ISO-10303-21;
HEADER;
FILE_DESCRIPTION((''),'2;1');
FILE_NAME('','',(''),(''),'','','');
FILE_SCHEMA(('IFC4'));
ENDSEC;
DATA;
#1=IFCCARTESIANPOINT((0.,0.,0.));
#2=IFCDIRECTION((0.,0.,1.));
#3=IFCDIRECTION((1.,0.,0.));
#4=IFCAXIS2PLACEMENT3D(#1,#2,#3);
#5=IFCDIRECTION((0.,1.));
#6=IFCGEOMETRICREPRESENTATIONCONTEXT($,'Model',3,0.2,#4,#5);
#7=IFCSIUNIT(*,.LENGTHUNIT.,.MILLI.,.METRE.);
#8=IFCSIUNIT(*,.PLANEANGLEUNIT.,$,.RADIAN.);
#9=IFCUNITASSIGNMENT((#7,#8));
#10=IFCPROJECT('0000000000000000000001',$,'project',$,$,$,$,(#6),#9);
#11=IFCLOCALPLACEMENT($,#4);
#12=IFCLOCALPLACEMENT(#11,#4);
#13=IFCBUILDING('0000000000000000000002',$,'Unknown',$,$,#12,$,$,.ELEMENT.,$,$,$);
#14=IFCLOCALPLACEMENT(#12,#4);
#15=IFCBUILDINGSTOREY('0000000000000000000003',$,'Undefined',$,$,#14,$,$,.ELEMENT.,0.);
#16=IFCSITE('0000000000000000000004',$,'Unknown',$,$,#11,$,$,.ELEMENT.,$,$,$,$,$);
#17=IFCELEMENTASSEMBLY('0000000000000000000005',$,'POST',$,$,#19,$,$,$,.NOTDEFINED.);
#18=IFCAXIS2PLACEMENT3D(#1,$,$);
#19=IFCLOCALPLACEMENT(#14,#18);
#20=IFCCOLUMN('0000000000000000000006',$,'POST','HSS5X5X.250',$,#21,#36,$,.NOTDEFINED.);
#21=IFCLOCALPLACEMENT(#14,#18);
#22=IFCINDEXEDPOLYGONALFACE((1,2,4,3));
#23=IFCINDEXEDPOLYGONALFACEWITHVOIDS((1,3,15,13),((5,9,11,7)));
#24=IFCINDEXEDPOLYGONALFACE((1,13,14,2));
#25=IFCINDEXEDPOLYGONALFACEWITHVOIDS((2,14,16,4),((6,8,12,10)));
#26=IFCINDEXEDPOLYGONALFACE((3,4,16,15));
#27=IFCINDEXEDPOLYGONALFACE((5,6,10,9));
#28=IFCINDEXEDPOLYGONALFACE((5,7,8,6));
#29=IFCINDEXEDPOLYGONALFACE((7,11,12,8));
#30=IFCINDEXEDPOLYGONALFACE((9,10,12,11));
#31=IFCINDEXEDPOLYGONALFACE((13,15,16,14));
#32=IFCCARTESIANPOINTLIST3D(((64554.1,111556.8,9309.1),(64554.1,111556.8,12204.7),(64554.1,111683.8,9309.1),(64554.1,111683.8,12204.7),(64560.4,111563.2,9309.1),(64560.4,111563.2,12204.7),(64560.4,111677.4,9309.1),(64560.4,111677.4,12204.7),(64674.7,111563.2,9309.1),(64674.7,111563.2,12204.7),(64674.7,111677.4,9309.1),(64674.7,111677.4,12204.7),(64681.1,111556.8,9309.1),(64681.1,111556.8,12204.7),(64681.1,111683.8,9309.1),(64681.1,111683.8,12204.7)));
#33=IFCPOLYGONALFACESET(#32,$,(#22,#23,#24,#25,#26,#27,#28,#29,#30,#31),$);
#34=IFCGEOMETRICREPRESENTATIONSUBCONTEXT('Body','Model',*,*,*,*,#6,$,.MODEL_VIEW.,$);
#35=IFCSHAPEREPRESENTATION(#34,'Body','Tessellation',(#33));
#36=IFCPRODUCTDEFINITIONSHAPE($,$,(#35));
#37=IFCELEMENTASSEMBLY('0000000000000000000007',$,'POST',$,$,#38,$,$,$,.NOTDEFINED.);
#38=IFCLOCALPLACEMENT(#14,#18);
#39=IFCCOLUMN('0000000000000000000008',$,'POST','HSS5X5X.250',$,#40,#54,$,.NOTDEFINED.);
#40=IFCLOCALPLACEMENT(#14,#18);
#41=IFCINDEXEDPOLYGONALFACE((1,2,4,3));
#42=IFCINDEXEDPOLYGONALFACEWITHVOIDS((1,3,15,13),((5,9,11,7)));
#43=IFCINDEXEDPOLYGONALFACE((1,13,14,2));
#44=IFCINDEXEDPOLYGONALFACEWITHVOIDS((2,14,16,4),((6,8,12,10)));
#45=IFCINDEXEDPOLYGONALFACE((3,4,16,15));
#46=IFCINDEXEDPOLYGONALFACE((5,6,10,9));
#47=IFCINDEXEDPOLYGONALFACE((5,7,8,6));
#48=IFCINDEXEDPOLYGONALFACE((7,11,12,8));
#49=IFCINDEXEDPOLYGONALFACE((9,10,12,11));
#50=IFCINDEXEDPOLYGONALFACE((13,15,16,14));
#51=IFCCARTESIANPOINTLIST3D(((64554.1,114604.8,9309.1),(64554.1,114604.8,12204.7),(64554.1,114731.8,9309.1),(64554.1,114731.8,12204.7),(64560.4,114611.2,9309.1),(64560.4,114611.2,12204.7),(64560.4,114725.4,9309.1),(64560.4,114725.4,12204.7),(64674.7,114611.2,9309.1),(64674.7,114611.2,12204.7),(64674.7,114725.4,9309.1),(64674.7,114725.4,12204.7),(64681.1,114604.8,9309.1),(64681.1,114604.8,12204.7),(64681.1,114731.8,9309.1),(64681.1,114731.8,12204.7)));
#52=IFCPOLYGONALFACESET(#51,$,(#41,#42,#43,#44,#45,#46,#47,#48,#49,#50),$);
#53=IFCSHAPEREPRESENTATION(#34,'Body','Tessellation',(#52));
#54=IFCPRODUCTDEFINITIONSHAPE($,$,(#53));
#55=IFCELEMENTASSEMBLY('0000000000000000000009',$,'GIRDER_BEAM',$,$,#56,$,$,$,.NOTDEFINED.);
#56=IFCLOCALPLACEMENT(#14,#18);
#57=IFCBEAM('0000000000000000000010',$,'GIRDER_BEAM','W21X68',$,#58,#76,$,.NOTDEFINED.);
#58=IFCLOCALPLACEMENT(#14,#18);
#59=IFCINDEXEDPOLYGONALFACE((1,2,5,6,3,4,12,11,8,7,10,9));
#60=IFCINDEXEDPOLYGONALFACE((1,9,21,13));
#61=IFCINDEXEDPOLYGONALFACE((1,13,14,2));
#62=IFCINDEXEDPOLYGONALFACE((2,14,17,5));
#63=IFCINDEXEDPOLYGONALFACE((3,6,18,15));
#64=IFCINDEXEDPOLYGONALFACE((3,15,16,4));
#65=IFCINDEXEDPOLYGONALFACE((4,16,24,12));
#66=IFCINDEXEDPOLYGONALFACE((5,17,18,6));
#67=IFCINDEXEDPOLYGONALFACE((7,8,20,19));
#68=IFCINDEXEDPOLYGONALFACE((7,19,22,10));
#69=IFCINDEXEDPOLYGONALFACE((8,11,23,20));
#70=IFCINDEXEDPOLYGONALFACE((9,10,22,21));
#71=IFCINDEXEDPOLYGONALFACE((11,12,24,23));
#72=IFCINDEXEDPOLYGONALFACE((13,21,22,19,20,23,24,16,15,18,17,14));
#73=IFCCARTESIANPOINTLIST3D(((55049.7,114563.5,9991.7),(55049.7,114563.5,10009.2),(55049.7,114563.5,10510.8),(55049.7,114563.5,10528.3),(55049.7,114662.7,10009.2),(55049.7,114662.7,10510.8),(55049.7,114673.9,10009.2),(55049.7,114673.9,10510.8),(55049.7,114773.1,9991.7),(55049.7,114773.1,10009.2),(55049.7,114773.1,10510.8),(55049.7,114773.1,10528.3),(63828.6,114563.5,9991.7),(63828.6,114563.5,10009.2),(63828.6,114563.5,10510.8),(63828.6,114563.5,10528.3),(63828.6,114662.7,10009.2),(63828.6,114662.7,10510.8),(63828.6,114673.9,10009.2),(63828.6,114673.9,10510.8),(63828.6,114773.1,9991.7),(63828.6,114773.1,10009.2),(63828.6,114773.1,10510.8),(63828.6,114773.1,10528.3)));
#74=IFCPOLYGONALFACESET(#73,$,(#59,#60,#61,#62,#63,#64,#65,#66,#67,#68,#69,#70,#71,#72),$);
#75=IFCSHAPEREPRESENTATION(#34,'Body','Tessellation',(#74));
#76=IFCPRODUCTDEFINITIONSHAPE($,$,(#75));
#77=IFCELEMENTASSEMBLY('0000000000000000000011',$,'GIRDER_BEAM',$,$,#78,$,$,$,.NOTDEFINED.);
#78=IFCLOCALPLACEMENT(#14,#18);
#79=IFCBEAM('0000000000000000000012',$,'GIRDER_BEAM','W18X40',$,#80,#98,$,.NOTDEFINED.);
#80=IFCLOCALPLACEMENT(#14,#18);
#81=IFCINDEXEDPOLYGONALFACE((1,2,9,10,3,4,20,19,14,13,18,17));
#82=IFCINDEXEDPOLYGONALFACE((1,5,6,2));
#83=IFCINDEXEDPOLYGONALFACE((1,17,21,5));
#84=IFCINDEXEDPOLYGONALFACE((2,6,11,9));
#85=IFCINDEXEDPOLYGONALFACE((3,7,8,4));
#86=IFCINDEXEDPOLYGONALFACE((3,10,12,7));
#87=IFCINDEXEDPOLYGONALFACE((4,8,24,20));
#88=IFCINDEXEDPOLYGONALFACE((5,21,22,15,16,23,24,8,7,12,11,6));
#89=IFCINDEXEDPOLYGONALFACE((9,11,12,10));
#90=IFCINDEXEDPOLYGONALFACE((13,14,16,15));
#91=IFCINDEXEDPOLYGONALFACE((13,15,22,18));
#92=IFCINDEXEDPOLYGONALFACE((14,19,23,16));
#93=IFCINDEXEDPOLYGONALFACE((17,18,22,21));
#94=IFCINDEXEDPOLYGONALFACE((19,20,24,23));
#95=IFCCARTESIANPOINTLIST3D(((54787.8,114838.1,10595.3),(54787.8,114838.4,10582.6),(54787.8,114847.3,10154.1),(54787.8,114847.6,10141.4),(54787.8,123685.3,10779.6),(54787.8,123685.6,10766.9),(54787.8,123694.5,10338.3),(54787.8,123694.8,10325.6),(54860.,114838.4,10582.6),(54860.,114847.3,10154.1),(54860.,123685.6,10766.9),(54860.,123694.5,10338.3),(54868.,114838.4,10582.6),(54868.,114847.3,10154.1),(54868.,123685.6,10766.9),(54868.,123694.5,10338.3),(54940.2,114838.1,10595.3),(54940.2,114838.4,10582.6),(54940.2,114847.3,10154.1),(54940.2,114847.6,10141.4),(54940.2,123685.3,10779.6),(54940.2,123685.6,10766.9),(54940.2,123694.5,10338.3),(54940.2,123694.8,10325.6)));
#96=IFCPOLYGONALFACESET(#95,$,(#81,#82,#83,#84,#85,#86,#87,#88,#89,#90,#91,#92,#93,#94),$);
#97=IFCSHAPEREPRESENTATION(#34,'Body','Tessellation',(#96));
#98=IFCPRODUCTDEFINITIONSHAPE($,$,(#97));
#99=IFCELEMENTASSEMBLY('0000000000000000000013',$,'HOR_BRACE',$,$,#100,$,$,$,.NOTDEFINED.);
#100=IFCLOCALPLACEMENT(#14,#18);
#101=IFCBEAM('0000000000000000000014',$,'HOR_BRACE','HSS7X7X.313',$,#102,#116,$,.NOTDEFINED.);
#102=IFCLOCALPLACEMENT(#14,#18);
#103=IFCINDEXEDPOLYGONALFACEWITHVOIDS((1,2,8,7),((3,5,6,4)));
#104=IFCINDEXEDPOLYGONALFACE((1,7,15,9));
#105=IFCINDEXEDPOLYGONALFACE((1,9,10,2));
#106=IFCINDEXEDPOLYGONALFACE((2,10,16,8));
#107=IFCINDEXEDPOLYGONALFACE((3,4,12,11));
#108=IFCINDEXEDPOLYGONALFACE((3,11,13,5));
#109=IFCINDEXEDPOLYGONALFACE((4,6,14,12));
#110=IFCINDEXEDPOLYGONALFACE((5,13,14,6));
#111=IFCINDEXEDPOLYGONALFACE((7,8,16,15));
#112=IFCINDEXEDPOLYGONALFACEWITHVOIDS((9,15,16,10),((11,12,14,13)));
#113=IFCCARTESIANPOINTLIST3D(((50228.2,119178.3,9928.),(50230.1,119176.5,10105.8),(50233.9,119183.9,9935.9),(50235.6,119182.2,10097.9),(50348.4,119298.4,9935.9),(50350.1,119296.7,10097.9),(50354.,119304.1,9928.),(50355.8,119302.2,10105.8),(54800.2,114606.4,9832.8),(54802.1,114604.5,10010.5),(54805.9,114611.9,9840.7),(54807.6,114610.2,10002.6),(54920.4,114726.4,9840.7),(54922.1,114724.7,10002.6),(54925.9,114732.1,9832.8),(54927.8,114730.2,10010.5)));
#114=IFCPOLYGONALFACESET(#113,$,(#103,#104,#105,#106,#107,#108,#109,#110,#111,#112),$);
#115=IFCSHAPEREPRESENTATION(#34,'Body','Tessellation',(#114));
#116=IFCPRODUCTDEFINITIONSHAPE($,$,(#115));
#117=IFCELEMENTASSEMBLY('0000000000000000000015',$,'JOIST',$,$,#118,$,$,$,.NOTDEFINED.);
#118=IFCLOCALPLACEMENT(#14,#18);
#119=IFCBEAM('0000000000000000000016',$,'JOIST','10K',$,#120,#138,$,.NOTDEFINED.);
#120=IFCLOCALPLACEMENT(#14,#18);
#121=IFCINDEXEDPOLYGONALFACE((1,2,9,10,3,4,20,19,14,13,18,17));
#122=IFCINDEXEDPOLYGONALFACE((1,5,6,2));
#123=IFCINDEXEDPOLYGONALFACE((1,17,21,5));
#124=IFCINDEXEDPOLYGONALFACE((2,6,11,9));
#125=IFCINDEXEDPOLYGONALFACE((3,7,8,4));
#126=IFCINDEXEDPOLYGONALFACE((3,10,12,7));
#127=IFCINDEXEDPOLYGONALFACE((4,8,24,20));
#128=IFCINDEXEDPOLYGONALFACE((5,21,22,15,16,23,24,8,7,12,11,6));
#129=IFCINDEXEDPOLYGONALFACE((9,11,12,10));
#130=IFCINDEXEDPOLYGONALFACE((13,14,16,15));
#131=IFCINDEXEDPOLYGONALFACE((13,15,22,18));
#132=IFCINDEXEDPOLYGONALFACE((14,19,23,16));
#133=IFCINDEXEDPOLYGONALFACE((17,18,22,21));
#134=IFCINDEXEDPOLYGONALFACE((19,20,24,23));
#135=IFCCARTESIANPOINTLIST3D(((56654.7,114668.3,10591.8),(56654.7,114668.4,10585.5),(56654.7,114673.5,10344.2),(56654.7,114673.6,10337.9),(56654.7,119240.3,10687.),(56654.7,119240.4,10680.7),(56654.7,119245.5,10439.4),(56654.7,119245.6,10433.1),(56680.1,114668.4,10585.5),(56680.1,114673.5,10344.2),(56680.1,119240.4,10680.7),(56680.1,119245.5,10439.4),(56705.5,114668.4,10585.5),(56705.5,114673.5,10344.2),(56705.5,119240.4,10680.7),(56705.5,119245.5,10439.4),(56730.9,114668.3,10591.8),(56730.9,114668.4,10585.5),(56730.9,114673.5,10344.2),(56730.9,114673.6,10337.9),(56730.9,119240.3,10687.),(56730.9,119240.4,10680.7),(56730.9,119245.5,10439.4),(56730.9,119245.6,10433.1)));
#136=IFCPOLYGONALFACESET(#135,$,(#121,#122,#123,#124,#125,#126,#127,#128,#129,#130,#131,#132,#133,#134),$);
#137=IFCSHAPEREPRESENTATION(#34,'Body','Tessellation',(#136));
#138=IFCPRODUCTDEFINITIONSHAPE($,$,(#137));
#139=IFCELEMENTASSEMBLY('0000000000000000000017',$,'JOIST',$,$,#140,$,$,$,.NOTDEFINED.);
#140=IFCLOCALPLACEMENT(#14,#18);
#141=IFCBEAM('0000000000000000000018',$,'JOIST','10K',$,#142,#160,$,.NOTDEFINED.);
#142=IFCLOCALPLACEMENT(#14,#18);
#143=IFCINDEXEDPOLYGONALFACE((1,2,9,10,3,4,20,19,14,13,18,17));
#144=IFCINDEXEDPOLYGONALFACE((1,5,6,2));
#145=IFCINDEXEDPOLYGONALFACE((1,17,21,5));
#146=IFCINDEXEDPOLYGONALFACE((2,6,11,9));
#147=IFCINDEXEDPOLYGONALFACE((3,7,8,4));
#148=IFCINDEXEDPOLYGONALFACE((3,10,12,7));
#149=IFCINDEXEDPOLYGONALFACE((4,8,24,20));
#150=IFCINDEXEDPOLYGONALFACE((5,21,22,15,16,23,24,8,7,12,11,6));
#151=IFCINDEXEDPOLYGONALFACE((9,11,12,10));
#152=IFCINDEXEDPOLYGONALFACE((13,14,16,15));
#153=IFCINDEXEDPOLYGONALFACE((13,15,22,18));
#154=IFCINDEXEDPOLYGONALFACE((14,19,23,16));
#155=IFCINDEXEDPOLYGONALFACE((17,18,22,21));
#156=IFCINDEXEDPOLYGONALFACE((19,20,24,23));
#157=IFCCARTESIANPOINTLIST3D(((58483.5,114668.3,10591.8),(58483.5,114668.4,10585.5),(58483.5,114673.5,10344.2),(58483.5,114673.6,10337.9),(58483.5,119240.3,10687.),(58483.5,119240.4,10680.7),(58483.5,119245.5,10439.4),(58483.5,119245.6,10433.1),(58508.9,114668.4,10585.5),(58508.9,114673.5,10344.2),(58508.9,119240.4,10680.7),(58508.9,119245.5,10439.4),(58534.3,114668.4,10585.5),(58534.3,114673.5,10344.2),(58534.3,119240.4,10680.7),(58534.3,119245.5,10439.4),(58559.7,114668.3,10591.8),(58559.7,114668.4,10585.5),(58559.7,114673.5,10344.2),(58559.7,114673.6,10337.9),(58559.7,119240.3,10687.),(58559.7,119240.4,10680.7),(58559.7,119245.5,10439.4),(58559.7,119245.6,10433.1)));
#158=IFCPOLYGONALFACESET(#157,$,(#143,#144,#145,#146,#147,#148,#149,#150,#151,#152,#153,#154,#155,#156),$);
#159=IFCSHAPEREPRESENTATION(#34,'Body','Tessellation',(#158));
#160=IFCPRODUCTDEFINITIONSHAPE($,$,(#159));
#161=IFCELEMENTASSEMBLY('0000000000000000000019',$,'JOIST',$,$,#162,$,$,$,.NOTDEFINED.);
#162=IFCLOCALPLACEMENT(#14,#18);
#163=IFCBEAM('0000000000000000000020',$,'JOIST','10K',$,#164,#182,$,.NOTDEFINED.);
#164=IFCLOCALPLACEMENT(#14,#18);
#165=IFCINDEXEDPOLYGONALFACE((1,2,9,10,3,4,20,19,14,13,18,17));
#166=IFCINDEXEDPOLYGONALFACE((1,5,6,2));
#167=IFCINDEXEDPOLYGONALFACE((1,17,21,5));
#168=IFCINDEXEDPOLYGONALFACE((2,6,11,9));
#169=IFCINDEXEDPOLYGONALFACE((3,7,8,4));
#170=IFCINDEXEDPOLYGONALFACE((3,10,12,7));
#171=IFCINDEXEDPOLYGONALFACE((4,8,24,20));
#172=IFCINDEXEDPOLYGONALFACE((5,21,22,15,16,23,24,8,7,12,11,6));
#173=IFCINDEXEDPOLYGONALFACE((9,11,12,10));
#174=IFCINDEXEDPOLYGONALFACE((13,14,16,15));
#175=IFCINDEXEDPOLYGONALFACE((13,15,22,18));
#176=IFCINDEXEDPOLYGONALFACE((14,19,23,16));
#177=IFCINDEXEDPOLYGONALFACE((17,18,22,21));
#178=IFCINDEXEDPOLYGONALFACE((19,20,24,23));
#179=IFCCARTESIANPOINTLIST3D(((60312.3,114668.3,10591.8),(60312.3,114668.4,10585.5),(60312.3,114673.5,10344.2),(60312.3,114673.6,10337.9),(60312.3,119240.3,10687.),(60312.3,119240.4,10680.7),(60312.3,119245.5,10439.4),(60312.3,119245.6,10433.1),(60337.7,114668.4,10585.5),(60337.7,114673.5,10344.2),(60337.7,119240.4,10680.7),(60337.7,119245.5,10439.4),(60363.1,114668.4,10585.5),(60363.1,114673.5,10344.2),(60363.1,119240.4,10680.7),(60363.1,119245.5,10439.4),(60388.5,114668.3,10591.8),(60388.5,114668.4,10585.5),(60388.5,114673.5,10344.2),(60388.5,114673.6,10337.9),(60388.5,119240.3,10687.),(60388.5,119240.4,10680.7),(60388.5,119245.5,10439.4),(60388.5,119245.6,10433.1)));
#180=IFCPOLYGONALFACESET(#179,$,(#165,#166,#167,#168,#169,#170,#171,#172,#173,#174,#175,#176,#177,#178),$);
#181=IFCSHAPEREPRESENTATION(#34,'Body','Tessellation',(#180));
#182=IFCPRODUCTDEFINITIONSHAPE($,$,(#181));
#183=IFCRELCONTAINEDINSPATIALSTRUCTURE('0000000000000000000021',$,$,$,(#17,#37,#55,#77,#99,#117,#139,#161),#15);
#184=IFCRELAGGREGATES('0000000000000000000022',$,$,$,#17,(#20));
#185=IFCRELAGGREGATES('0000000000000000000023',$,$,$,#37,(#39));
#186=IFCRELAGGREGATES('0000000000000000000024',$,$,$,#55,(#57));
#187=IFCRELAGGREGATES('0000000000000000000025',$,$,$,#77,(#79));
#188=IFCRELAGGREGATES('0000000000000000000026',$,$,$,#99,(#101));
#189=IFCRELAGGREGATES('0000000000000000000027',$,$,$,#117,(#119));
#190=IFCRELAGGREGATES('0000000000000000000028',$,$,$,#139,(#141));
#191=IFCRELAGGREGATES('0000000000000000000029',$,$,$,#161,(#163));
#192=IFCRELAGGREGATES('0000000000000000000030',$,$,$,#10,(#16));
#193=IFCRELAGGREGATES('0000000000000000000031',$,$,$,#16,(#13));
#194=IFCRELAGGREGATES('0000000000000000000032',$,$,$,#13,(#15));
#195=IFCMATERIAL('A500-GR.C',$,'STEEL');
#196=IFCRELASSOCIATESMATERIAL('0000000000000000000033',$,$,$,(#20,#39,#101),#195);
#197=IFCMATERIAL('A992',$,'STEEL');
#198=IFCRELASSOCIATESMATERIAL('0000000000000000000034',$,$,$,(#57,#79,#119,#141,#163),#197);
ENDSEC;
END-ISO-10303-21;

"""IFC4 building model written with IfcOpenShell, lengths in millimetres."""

from ifc_helpers import new_model, si_unit, direction, frame, origin_with_axes, place, context, subcontext, project, spatial, line, indexed_curve, outline, extrude, material, element, aggregate, save


model = new_model("IFC4")

# Units and contexts
model_context = context("Model", 3, precision=0.2, world=origin_with_axes(), true_north=direction((0.0, 1.0)))
body_context = subcontext(model_context, "Body", "Model", "MODEL_VIEW")
ifc_project = project(units=[si_unit("LENGTHUNIT", "METRE", prefix="MILLI"), si_unit("PLANEANGLEUNIT", "RADIAN")], contexts=[model_context])

# Site, building, storey
site_placement = place(None, origin_with_axes())
site = spatial("IfcSite", under=ifc_project, at=site_placement, Name="Unknown", CompositionType="ELEMENT")
building_placement = place(site_placement, origin_with_axes())
building = spatial("IfcBuilding", under=site, at=building_placement, Name="Unknown", CompositionType="ELEMENT")
storey_placement = place(building_placement, origin_with_axes())
storey = spatial("IfcBuildingStorey", under=building, at=storey_placement, Name="Undefined", CompositionType="ELEMENT", Elevation=0.0)

# Element assemblies, columns
assembly_1_placement = place(storey_placement, frame((64617.6, 111620.3, 9309.1), z_axis=(0.0, -1.0, 0.0), x_axis=(0.0, 0.0, 1.0)))
assembly_1 = element("IfcElementAssembly", 1, at=assembly_1_placement, inside=storey, Name="POST", PredefinedType="NOTDEFINED")
ifc_material_1 = material(Name="A500-GR.C", Category="STEEL")
column_1_placement = place(assembly_1_placement, origin_with_axes())
column_1 = element("IfcColumn", 2, at=column_1_placement, material=ifc_material_1, Name="POST", Description="HSS5X5X.250", PredefinedType="NOTDEFINED", context=body_context, shape_type="SolidModel", body=[
    extrude(outline(indexed_curve([(-63.5, -63.5), (63.5, -63.5), (63.5, 63.5), (-63.5, 63.5)], segments=[line(1, 2, 3, 4, 1)]), holes=[indexed_curve([(-57.1, -57.1), (-57.1, 57.1), (57.1, 57.1), (57.1, -57.1)], segments=[line(1, 2, 3, 4, 1)])]), frame((0.0, 0.0, 0.0), z_axis=(-1.0, 0.0, 0.0), x_axis=(0.0, 0.0, 1.0)), (0.0, 0.0, -1.0), 2895.6),
])
aggregate(assembly_1, [column_1])
assembly_2_placement = place(storey_placement, frame((64617.6, 114668.3, 9309.1), z_axis=(0.0, -1.0, 0.0), x_axis=(0.0, 0.0, 1.0)))
assembly_2 = element("IfcElementAssembly", 3, at=assembly_2_placement, inside=storey, Name="POST", PredefinedType="NOTDEFINED")
column_2_placement = place(assembly_2_placement, origin_with_axes())
column_2 = element("IfcColumn", 4, at=column_2_placement, material=ifc_material_1, Name="POST", Description="HSS5X5X.250", PredefinedType="NOTDEFINED", context=body_context, shape_type="SolidModel", body=[
    extrude(outline(indexed_curve([(-63.5, -63.5), (63.5, -63.5), (63.5, 63.5), (-63.5, 63.5)], segments=[line(1, 2, 3, 4, 1)]), holes=[indexed_curve([(-57.1, -57.1), (-57.1, 57.1), (57.1, 57.1), (57.1, -57.1)], segments=[line(1, 2, 3, 4, 1)])]), frame((0.0, 0.0, 0.0), z_axis=(-1.0, 0.0, 0.0), x_axis=(0.0, 0.0, 1.0)), (0.0, 0.0, -1.0), 2895.6),
])
aggregate(assembly_2, [column_2])

# Element assemblies, beams
assembly_3_placement = place(storey_placement, frame((55049.7, 114668.3, 10260.0), z_axis=(0.0, -1.0, 0.0), x_axis=(1.0, 0.0, 0.0)))
assembly_3 = element("IfcElementAssembly", 5, at=assembly_3_placement, inside=storey, Name="GIRDER_BEAM", PredefinedType="NOTDEFINED")
ifc_material_2 = material(Name="A992", Category="STEEL")
beam_1_placement = place(assembly_3_placement, origin_with_axes())
beam_1 = element("IfcBeam", 6, at=beam_1_placement, material=ifc_material_2, Name="GIRDER_BEAM", Description="W21X68", PredefinedType="NOTDEFINED", context=body_context, shape_type="SolidModel", body=[
    extrude(outline(indexed_curve([(-104.8, -268.3), (104.8, -268.3), (104.8, -250.8), (5.6, -250.8), (5.6, 250.8), (104.8, 250.8), (104.8, 268.3), (-104.8, 268.3), (-104.8, 250.8), (-5.6, 250.8), (-5.6, -250.8), (-104.8, -250.8)], segments=[line(1, 2, 3, 4, 5, 6, 7, 8, 9, 10, 11, 12, 1)])), frame((0.0, 0.0, 0.0), z_axis=(-1.0, 0.0, 0.0), x_axis=(0.0, 0.0, 1.0)), (0.0, 0.0, -1.0), 8778.9),
])
aggregate(assembly_3, [beam_1])
assembly_4_placement = place(storey_placement, frame((54864.0, 114842.9, 10368.4), z_axis=(1.0, 0.0, 0.0), x_axis=(0.0, 0.999783, 0.020819)))
assembly_4 = element("IfcElementAssembly", 7, at=assembly_4_placement, inside=storey, Name="GIRDER_BEAM", PredefinedType="NOTDEFINED")
beam_2_placement = place(assembly_4_placement, origin_with_axes())
beam_2 = element("IfcBeam", 8, at=beam_2_placement, material=ifc_material_2, Name="GIRDER_BEAM", Description="W18X40", PredefinedType="NOTDEFINED", context=body_context, shape_type="SolidModel", body=[
    extrude(outline(indexed_curve([(-76.2, -227.0), (76.2, -227.0), (76.2, -214.3), (4.0, -214.3), (4.0, 214.3), (76.2, 214.3), (76.2, 227.0), (-76.2, 227.0), (-76.2, 214.3), (-4.0, 214.3), (-4.0, -214.3), (-76.2, -214.3)], segments=[line(1, 2, 3, 4, 5, 6, 7, 8, 9, 10, 11, 12, 1)])), frame((0.0, 0.0, 0.0), z_axis=(-1.0, 0.0, 0.0), x_axis=(0.0, 0.0, 1.0)), (0.0, 0.0, -1.0), 8849.1),
])
aggregate(assembly_4, [beam_2])
assembly_5_placement = place(storey_placement, frame((54864.0, 114668.3, 9921.7), z_axis=(0.707107, 0.707107, 0.0), x_axis=(-0.70703, 0.70703, 0.01473)))
assembly_5 = element("IfcElementAssembly", 9, at=assembly_5_placement, inside=storey, Name="HOR_BRACE", PredefinedType="NOTDEFINED")
beam_3_placement = place(assembly_5_placement, origin_with_axes())
beam_3 = element("IfcBeam", 10, at=beam_3_placement, material=ifc_material_1, Name="HOR_BRACE", Description="HSS7X7X.313", PredefinedType="NOTDEFINED", context=body_context, shape_type="SolidModel", body=[
    extrude(outline(indexed_curve([(-88.9, -88.9), (88.9, -88.9), (88.9, 88.9), (-88.9, 88.9)], segments=[line(1, 2, 3, 4, 1)]), holes=[indexed_curve([(-81.0, -81.0), (-81.0, 81.0), (81.0, 81.0), (81.0, -81.0)], segments=[line(1, 2, 3, 4, 1)])]), frame((0.0, 0.0, 0.0), z_axis=(-1.0, 0.0, 0.0), x_axis=(0.0, 0.0, 1.0)), (0.0, 0.0, -1.0), 6466.5),
])
aggregate(assembly_5, [beam_3])
assembly_6_placement = place(storey_placement, frame((56692.8, 114670.9, 10464.8), z_axis=(1.0, 0.0, 0.0), x_axis=(0.0, 0.999783, 0.020819)))
assembly_6 = element("IfcElementAssembly", 11, at=assembly_6_placement, inside=storey, Name="JOIST", PredefinedType="NOTDEFINED")
beam_4_placement = place(assembly_6_placement, origin_with_axes())
beam_4 = element("IfcBeam", 12, at=beam_4_placement, material=ifc_material_2, Name="JOIST", Description="10K", PredefinedType="NOTDEFINED", context=body_context, shape_type="SolidModel", body=[
    extrude(outline(indexed_curve([(-38.1, -127.0), (38.1, -127.0), (38.1, -120.7), (12.7, -120.7), (12.7, 120.7), (38.1, 120.7), (38.1, 127.0), (-38.1, 127.0), (-38.1, 120.7), (-12.7, 120.7), (-12.7, -120.7), (-38.1, -120.7)], segments=[line(1, 2, 3, 4, 5, 6, 7, 8, 9, 10, 11, 12, 1)])), frame((0.0, 0.0, 0.0), z_axis=(-1.0, 0.0, 0.0), x_axis=(0.0, 0.0, 1.0)), (0.0, 0.0, -1.0), 4573.0),
])
aggregate(assembly_6, [beam_4])
assembly_7_placement = place(storey_placement, frame((58521.6, 114670.9, 10464.8), z_axis=(1.0, 0.0, 0.0), x_axis=(0.0, 0.999783, 0.020819)))
assembly_7 = element("IfcElementAssembly", 13, at=assembly_7_placement, inside=storey, Name="JOIST", PredefinedType="NOTDEFINED")
beam_5_placement = place(assembly_7_placement, origin_with_axes())
beam_5 = element("IfcBeam", 14, at=beam_5_placement, material=ifc_material_2, Name="JOIST", Description="10K", PredefinedType="NOTDEFINED", context=body_context, shape_type="SolidModel", body=[
    extrude(outline(indexed_curve([(-38.1, -127.0), (38.1, -127.0), (38.1, -120.7), (12.7, -120.7), (12.7, 120.7), (38.1, 120.7), (38.1, 127.0), (-38.1, 127.0), (-38.1, 120.7), (-12.7, 120.7), (-12.7, -120.7), (-38.1, -120.7)], segments=[line(1, 2, 3, 4, 5, 6, 7, 8, 9, 10, 11, 12, 1)])), frame((0.0, 0.0, 0.0), z_axis=(-1.0, 0.0, 0.0), x_axis=(0.0, 0.0, 1.0)), (0.0, 0.0, -1.0), 4573.0),
])
aggregate(assembly_7, [beam_5])
assembly_8_placement = place(storey_placement, frame((60350.4, 114670.9, 10464.8), z_axis=(1.0, 0.0, 0.0), x_axis=(0.0, 0.999783, 0.020819)))
assembly_8 = element("IfcElementAssembly", 15, at=assembly_8_placement, inside=storey, Name="JOIST", PredefinedType="NOTDEFINED")
beam_6_placement = place(assembly_8_placement, origin_with_axes())
beam_6 = element("IfcBeam", 16, at=beam_6_placement, material=ifc_material_2, Name="JOIST", Description="10K", PredefinedType="NOTDEFINED", context=body_context, shape_type="SolidModel", body=[
    extrude(outline(indexed_curve([(-38.1, -127.0), (38.1, -127.0), (38.1, -120.7), (12.7, -120.7), (12.7, 120.7), (38.1, 120.7), (38.1, 127.0), (-38.1, 127.0), (-38.1, 120.7), (-12.7, 120.7), (-12.7, -120.7), (-38.1, -120.7)], segments=[line(1, 2, 3, 4, 5, 6, 7, 8, 9, 10, 11, 12, 1)])), frame((0.0, 0.0, 0.0), z_axis=(-1.0, 0.0, 0.0), x_axis=(0.0, 0.0, 1.0)), (0.0, 0.0, -1.0), 4573.0),
])
aggregate(assembly_8, [beam_6])

save(model, "model.ifc")
